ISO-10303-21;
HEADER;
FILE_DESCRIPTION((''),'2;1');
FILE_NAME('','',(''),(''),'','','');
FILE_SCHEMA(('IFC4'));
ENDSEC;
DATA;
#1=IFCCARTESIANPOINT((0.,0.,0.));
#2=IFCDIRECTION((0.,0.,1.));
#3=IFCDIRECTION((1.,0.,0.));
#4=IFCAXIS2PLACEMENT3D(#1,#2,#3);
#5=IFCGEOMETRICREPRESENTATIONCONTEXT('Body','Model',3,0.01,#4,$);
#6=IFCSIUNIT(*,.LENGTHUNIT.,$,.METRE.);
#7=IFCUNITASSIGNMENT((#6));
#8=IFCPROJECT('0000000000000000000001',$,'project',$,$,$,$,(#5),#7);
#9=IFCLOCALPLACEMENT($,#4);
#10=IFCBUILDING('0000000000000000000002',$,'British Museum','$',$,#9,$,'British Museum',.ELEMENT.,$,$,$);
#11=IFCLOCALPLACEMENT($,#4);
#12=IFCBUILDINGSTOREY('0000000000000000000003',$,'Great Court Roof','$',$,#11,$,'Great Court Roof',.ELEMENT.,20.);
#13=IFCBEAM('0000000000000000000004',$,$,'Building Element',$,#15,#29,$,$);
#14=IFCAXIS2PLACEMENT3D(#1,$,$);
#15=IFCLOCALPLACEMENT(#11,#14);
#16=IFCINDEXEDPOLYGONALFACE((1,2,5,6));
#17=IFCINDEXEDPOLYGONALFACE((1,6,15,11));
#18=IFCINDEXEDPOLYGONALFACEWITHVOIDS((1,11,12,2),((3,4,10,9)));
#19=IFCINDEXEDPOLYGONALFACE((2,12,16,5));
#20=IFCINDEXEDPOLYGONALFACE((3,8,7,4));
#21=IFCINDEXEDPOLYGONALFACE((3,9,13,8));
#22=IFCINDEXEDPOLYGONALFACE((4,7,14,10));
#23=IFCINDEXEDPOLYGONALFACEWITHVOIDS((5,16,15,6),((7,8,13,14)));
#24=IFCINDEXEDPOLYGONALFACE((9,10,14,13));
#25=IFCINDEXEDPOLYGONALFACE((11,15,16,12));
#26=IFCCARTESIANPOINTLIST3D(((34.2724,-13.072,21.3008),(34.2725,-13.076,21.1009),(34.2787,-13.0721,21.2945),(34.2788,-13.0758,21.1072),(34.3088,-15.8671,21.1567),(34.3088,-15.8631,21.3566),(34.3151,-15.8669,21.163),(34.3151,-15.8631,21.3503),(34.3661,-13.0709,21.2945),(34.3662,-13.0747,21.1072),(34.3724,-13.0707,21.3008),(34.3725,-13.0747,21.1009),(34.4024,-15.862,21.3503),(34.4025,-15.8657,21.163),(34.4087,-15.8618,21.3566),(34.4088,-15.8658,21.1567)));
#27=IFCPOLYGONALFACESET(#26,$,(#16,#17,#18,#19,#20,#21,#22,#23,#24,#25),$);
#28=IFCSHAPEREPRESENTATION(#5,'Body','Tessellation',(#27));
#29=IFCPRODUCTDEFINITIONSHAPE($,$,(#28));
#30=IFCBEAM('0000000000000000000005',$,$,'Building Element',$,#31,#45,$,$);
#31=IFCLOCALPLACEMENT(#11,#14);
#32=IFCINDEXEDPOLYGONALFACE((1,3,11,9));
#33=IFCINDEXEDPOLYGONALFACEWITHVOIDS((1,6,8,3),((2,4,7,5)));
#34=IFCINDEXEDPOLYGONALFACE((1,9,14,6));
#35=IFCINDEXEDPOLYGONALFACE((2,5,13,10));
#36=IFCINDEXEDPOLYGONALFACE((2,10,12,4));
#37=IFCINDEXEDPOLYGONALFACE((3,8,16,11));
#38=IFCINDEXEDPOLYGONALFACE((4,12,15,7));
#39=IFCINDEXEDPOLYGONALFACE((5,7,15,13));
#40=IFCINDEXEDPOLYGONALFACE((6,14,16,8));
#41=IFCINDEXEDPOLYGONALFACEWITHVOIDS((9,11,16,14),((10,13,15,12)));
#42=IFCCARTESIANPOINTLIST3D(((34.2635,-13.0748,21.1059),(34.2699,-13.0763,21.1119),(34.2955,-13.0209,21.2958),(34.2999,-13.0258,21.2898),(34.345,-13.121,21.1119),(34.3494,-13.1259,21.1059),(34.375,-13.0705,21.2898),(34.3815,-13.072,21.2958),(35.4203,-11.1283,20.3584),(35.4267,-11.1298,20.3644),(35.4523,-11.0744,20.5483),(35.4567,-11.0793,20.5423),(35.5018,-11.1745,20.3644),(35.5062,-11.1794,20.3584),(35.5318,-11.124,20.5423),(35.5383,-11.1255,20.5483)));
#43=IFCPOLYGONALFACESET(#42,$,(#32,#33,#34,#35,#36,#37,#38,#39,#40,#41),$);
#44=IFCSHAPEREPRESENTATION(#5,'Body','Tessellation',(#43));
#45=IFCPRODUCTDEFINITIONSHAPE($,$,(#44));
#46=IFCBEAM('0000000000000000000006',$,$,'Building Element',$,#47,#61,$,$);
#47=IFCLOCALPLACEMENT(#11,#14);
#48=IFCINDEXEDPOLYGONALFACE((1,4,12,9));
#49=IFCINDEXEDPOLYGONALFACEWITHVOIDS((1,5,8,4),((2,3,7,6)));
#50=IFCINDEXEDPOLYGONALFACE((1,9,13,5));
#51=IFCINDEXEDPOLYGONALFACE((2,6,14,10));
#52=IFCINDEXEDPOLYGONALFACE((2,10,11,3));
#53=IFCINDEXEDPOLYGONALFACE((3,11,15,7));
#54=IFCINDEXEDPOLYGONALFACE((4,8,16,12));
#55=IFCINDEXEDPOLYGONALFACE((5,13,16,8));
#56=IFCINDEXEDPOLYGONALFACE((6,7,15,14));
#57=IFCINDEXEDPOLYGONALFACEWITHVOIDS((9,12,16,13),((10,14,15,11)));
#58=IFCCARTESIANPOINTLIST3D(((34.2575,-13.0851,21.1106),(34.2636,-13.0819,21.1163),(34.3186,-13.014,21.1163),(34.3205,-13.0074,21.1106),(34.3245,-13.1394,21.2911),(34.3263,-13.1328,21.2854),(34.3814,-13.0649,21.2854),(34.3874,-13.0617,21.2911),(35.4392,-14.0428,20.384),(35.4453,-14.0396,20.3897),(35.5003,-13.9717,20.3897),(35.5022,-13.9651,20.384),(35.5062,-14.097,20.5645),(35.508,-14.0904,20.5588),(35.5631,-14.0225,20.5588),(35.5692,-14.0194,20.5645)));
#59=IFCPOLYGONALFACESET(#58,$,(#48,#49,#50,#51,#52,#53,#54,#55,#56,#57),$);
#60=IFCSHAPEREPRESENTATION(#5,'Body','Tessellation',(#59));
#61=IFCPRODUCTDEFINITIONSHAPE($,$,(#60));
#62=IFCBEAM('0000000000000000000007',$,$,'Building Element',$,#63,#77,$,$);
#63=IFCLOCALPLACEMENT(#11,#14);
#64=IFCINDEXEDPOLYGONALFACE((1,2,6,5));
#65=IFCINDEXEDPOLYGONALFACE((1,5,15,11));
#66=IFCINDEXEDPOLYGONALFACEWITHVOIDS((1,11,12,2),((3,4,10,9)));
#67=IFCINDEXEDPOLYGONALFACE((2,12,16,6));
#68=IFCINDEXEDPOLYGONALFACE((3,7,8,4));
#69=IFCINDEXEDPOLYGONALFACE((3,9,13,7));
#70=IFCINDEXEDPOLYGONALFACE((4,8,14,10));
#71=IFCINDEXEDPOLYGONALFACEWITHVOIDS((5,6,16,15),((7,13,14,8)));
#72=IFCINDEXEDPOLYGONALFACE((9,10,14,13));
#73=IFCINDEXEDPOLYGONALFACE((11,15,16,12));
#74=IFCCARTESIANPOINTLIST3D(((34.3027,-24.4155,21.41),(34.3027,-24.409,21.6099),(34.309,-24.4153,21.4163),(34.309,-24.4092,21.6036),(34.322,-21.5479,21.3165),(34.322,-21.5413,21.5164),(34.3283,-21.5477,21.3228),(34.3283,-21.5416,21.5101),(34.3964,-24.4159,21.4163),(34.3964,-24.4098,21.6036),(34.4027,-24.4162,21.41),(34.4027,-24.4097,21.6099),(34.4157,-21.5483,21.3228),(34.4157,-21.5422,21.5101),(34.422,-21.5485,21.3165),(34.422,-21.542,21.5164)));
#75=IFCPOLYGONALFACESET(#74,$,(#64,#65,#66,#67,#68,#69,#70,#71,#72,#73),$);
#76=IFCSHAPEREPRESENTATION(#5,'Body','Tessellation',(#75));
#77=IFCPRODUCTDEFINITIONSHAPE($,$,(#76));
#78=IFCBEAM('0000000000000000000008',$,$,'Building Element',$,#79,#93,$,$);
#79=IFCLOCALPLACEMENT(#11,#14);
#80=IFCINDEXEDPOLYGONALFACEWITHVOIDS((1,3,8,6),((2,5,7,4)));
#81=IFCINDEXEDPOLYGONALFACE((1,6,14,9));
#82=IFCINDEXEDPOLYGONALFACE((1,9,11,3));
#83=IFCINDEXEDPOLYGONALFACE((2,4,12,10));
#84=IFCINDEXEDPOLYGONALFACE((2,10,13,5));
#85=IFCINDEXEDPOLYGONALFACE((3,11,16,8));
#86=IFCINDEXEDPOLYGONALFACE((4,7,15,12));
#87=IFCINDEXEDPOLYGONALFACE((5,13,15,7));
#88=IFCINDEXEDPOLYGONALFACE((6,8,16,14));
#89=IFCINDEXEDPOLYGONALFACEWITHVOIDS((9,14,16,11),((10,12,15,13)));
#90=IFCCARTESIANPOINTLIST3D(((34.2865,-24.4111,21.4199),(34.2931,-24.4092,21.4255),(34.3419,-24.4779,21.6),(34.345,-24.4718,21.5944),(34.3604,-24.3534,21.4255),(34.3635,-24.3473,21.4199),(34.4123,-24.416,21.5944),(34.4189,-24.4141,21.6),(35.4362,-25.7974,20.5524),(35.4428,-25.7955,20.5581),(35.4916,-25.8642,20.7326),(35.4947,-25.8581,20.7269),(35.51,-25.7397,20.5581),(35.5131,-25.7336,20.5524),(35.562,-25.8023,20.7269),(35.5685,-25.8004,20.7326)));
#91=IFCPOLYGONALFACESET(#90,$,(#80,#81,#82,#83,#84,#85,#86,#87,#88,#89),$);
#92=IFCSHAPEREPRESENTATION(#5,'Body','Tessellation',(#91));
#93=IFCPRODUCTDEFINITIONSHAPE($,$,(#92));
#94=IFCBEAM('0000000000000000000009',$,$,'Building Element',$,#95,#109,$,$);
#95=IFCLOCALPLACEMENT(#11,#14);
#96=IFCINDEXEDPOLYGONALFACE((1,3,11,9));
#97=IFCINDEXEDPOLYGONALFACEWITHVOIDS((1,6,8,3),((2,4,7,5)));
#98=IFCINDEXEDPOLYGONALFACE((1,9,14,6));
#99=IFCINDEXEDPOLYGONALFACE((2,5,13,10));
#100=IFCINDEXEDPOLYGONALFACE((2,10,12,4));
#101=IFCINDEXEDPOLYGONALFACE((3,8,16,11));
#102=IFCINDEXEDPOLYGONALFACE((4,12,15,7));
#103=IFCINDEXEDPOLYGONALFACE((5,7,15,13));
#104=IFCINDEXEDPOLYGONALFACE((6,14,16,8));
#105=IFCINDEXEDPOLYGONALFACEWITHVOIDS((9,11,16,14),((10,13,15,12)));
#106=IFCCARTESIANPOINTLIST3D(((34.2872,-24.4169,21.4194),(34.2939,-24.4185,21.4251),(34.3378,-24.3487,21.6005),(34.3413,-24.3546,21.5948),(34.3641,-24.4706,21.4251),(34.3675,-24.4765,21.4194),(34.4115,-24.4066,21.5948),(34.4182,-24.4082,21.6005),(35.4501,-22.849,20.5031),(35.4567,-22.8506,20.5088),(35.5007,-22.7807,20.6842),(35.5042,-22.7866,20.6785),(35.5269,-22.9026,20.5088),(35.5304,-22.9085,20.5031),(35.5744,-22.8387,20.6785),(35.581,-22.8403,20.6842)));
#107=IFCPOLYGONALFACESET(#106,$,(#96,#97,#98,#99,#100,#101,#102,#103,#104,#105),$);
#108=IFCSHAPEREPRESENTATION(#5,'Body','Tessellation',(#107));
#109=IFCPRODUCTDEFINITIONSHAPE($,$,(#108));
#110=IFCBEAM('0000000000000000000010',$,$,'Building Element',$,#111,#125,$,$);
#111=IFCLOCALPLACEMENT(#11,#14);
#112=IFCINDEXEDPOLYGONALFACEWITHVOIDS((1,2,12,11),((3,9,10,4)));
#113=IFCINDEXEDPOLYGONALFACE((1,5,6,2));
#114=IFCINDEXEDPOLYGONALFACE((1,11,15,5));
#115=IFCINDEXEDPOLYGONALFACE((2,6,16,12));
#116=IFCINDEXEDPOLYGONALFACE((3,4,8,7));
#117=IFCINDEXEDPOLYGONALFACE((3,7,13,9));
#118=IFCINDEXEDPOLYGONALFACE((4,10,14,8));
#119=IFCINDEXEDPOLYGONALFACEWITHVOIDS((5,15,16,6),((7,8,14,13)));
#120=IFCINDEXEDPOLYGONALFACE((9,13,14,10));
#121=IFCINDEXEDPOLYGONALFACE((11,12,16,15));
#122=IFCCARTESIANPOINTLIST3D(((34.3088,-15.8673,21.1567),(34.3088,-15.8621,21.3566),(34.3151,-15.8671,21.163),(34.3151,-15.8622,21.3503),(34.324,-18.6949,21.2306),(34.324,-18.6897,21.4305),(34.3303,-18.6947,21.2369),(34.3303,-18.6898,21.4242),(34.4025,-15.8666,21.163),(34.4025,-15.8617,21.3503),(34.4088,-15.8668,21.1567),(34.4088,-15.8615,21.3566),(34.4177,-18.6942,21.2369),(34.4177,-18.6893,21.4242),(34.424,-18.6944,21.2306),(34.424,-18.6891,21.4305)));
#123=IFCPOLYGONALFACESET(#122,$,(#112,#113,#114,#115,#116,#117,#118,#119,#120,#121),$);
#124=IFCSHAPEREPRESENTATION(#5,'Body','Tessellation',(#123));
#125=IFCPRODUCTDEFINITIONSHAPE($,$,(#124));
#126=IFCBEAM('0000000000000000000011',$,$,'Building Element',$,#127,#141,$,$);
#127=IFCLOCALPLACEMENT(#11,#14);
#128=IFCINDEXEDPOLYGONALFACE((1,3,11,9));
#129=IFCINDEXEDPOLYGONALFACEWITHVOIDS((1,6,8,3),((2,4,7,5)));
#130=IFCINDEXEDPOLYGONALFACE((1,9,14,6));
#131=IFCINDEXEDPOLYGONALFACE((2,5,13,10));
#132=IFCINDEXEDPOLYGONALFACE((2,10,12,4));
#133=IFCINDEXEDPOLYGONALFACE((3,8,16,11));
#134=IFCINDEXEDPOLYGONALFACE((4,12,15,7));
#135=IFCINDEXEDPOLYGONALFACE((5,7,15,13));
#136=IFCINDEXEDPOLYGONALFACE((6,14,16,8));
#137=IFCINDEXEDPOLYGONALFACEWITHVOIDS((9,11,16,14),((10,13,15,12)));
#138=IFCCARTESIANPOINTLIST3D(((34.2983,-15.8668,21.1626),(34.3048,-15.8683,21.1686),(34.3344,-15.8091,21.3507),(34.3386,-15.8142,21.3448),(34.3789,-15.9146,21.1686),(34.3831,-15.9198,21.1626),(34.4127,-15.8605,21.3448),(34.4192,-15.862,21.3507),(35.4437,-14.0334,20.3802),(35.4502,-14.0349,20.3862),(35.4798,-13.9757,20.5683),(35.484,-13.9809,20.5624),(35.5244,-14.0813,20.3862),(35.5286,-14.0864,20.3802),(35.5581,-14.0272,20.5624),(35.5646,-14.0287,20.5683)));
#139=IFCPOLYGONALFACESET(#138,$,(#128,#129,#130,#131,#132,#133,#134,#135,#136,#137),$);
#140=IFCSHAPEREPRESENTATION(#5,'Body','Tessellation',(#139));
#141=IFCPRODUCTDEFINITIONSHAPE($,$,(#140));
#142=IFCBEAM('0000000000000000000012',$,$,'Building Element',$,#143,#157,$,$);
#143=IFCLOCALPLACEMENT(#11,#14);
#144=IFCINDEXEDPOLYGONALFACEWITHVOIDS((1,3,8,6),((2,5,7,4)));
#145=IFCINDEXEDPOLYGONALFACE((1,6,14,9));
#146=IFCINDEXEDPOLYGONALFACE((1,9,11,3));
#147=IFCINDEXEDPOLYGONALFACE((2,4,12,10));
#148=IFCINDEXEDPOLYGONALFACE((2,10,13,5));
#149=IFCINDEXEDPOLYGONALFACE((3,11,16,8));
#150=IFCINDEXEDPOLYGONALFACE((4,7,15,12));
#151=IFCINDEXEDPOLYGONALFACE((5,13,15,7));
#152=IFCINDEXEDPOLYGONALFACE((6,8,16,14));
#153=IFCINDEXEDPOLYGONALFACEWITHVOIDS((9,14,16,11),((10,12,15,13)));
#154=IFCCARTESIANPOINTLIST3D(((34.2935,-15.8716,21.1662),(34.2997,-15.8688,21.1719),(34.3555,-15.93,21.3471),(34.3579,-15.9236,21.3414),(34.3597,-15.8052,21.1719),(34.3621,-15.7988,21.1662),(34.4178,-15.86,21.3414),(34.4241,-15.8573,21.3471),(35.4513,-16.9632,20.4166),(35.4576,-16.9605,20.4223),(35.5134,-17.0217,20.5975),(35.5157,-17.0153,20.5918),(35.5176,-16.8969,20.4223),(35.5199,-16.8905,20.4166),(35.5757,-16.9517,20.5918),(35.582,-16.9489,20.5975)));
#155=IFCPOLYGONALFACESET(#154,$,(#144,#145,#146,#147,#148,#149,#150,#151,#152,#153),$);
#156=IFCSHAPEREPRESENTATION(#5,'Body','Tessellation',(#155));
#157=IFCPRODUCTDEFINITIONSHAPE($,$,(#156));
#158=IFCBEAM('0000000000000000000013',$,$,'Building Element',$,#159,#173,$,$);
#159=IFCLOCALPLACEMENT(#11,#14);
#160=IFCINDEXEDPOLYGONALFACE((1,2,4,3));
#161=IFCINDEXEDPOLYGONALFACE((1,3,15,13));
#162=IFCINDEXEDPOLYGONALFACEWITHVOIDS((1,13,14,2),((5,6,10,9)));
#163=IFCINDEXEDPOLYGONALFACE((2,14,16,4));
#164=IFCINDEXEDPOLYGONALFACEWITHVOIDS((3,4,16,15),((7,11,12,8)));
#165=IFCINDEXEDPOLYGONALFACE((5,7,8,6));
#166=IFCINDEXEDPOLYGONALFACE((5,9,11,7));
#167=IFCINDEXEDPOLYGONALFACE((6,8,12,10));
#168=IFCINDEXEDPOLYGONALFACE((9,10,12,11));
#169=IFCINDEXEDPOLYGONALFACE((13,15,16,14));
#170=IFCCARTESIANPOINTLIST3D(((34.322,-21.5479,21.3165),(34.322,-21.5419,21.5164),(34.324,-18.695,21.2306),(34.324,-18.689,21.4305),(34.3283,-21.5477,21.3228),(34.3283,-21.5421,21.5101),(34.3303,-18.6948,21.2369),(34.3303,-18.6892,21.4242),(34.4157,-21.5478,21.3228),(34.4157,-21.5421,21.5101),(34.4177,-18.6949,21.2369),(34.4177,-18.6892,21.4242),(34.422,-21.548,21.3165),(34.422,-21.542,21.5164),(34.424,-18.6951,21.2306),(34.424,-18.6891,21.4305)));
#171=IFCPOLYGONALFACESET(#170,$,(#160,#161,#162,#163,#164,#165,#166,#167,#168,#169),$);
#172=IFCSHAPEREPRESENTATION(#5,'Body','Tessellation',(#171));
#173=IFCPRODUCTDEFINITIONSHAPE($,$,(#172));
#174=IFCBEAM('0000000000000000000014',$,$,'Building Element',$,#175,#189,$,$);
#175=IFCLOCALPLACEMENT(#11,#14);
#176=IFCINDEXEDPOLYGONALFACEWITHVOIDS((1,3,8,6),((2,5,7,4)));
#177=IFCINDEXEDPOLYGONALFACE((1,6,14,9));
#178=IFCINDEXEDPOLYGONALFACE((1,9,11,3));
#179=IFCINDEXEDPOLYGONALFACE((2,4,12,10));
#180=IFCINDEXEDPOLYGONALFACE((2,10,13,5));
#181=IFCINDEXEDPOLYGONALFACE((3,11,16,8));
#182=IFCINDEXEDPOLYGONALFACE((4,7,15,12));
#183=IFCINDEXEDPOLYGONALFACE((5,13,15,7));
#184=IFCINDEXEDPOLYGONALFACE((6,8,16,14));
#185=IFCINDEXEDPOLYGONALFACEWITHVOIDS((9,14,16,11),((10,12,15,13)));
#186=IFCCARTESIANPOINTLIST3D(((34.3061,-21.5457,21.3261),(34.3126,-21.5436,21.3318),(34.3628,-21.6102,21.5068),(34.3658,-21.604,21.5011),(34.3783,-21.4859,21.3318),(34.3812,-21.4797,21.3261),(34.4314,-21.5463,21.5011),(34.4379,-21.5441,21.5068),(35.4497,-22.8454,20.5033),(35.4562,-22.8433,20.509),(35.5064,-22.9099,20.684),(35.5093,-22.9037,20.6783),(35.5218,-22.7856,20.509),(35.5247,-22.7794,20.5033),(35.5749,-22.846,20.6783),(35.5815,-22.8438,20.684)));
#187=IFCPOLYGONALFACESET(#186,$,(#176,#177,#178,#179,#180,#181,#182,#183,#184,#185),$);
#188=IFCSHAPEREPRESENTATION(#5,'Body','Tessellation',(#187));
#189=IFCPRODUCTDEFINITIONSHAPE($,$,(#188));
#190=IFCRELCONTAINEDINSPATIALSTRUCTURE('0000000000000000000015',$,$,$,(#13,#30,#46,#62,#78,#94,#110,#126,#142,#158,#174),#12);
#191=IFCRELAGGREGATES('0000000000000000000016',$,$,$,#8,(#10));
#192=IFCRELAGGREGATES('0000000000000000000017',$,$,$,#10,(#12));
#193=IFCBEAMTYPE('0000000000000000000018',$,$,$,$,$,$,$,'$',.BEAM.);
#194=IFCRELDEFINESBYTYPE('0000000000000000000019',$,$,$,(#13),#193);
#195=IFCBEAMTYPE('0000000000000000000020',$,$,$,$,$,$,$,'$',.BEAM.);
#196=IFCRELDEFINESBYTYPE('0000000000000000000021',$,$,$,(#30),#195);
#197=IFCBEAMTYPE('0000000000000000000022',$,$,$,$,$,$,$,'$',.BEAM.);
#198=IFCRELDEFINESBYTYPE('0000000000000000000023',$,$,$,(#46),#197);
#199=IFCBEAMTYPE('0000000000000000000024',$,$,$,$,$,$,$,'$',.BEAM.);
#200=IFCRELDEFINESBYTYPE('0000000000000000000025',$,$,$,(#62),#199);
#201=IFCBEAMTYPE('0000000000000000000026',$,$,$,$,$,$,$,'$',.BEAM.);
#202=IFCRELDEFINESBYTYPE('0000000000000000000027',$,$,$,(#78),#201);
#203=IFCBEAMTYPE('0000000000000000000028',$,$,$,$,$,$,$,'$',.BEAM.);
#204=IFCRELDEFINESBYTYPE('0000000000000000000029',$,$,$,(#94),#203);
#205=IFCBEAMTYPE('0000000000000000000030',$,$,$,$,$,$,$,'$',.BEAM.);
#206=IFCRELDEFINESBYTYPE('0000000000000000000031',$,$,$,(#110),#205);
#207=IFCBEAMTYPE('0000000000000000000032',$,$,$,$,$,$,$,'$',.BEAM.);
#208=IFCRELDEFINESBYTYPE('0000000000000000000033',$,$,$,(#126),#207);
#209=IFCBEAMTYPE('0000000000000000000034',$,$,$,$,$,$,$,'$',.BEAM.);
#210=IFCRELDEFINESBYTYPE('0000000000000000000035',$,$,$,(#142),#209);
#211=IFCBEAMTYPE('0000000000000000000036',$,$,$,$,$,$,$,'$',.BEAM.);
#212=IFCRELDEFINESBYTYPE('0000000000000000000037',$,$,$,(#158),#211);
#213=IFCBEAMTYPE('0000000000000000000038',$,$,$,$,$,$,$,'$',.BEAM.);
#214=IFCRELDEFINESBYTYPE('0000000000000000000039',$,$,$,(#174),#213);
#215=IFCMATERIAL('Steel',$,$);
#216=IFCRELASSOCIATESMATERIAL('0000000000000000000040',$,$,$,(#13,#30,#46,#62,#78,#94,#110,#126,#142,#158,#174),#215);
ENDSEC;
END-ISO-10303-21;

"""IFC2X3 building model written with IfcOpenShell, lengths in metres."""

from ifc_helpers import new_model, si_unit, frame, origin_with_axes, origin_2d, place, context, project, spatial, hollow_rectangle, extrude, material, type_object, element, save


model = new_model("IFC2X3")

# Units and contexts
model_context = context("Model", 3, precision=0.01, world=origin_with_axes(), identifier="Body")
ifc_project = project(units=[si_unit("LENGTHUNIT", "METRE")], contexts=[model_context])

# Building, storey
building_placement = place(None, origin_with_axes())
building = spatial("IfcBuilding", under=ifc_project, at=building_placement, Name="British Museum", Description="$", LongName="British Museum", CompositionType="ELEMENT")
storey_placement = place(None, origin_with_axes())
storey = spatial("IfcBuildingStorey", under=building, at=storey_placement, Name="Great Court Roof", Description="$", LongName="Great Court Roof", CompositionType="ELEMENT", Elevation=20.0)

# Beams
ifc_material = material(Name="Steel")
beam_type_1 = type_object("IfcBeamType", ElementType="$", PredefinedType="BEAM")
beam_1_placement = place(None, origin_with_axes())
element("IfcBeam", 1, at=beam_1_placement, inside=storey, type_object=beam_type_1, material=ifc_material, Description="Building Element", context=model_context, shape_type="SweptSolid", body=[
    extrude(hollow_rectangle(XDim=0.1, YDim=0.2, WallThickness=0.0063, InnerFilletRadius=-0.0063, OuterFilletRadius=0.0, at=origin_2d()), frame((34.3225, -13.0734, 21.2008), z_axis=(0.013007, -0.999715, 0.019998), x_axis=(0.999915, 0.013009, 0.0)), (0.0, 0.0, 1.0), 2.7918),
])
beam_type_2 = type_object("IfcBeamType", ElementType="$", PredefinedType="BEAM")
beam_2_placement = place(None, origin_with_axes())
element("IfcBeam", 2, at=beam_2_placement, inside=storey, type_object=beam_type_2, material=ifc_material, Description="Building Element", context=model_context, shape_type="SweptSolid", body=[
    extrude(hollow_rectangle(XDim=0.1, YDim=0.2, WallThickness=0.0063, InnerFilletRadius=-0.0063, OuterFilletRadius=0.0, at=origin_2d()), frame((34.3225, -13.0734, 21.2008), z_axis=(0.485142, 0.816313, -0.313481), x_axis=(-0.859644, 0.510894, 0.0)), (0.0, 0.0, 1.0), 2.3845),
])
beam_type_3 = type_object("IfcBeamType", ElementType="$", PredefinedType="BEAM")
beam_3_placement = place(None, origin_with_axes())
element("IfcBeam", 3, at=beam_3_placement, inside=storey, type_object=beam_type_3, material=ifc_material, Description="Building Element", context=model_context, shape_type="SweptSolid", body=[
    extrude(hollow_rectangle(XDim=0.1, YDim=0.2, WallThickness=0.0063, InnerFilletRadius=-0.0063, OuterFilletRadius=0.0, at=origin_2d()), frame((34.3225, -13.0734, 21.2008), z_axis=(0.701037, -0.568124, -0.431025), x_axis=(0.629612, 0.77691, 0.0)), (0.0, 0.0, 1.0), 1.6857),
])
beam_type_4 = type_object("IfcBeamType", ElementType="$", PredefinedType="BEAM")
beam_4_placement = place(None, origin_with_axes())
element("IfcBeam", 4, at=beam_4_placement, inside=storey, type_object=beam_type_4, material=ifc_material, Description="Building Element", context=model_context, shape_type="SweptSolid", body=[
    extrude(hollow_rectangle(XDim=0.1, YDim=0.2, WallThickness=0.0063, InnerFilletRadius=-0.0063, OuterFilletRadius=0.0, at=origin_2d()), frame((34.3527, -24.4126, 21.5099), z_axis=(0.006738, 0.999446, -0.032587), x_axis=(-0.999977, 0.006742, 0.0)), (0.0, 0.0, 1.0), 2.8692),
])
beam_type_5 = type_object("IfcBeamType", ElementType="$", PredefinedType="BEAM")
beam_5_placement = place(None, origin_with_axes())
element("IfcBeam", 5, at=beam_5_placement, inside=storey, type_object=beam_type_5, material=ifc_material, Description="Building Element", context=model_context, shape_type="SweptSolid", body=[
    extrude(hollow_rectangle(XDim=0.1, YDim=0.2, WallThickness=0.0063, InnerFilletRadius=-0.0063, OuterFilletRadius=0.0, at=origin_2d()), frame((34.3527, -24.4126, 21.5099), z_axis=(0.57512, -0.693506, -0.433921), x_axis=(0.769748, 0.638347, 0.0)), (0.0, 0.0, 1.0), 1.999),
])
beam_type_6 = type_object("IfcBeamType", ElementType="$", PredefinedType="BEAM")
beam_6_placement = place(None, origin_with_axes())
element("IfcBeam", 6, at=beam_6_placement, inside=storey, type_object=beam_type_6, material=ifc_material, Description="Building Element", context=model_context, shape_type="SweptSolid", body=[
    extrude(hollow_rectangle(XDim=0.1, YDim=0.2, WallThickness=0.0063, InnerFilletRadius=-0.0063, OuterFilletRadius=0.0, at=origin_2d()), frame((34.3527, -24.4126, 21.5099), z_axis=(0.539247, 0.727094, -0.424909), x_axis=(-0.803209, 0.595697, 0.0)), (0.0, 0.0, 1.0), 2.1565),
])
beam_type_7 = type_object("IfcBeamType", ElementType="$", PredefinedType="BEAM")
beam_7_placement = place(None, origin_with_axes())
element("IfcBeam", 7, at=beam_7_placement, inside=storey, type_object=beam_type_7, material=ifc_material, Description="Building Element", context=model_context, shape_type="SweptSolid", body=[
    extrude(hollow_rectangle(XDim=0.1, YDim=0.2, WallThickness=0.0063, InnerFilletRadius=-0.0063, OuterFilletRadius=0.0, at=origin_2d()), frame((34.3588, -15.8644, 21.2567), z_axis=(0.005392, -0.999644, 0.026112), x_axis=(0.999985, 0.005394, 0.0)), (0.0, 0.0, 1.0), 2.8286),
])
beam_type_8 = type_object("IfcBeamType", ElementType="$", PredefinedType="BEAM")
beam_8_placement = place(None, origin_with_axes())
element("IfcBeam", 8, at=beam_8_placement, inside=storey, type_object=beam_type_8, material=ifc_material, Description="Building Element", context=model_context, shape_type="SweptSolid", body=[
    extrude(hollow_rectangle(XDim=0.1, YDim=0.2, WallThickness=0.0063, InnerFilletRadius=-0.0063, OuterFilletRadius=0.0, at=origin_2d()), frame((34.3588, -15.8644, 21.2567), z_axis=(0.498225, 0.797466, -0.340324), x_axis=(-0.84809, 0.529852, 0.0)), (0.0, 0.0, 1.0), 2.299),
])
beam_type_9 = type_object("IfcBeamType", ElementType="$", PredefinedType="BEAM")
beam_9_placement = place(None, origin_with_axes())
element("IfcBeam", 9, at=beam_9_placement, inside=storey, type_object=beam_type_9, material=ifc_material, Description="Building Element", context=model_context, shape_type="SweptSolid", body=[
    extrude(hollow_rectangle(XDim=0.1, YDim=0.2, WallThickness=0.0063, InnerFilletRadius=-0.0063, OuterFilletRadius=0.0, at=origin_2d()), frame((34.3588, -15.8644, 21.2567), z_axis=(0.658228, -0.62059, -0.42615), x_axis=(0.685999, 0.727603, 0.0)), (0.0, 0.0, 1.0), 1.7591),
])
beam_type_10 = type_object("IfcBeamType", ElementType="$", PredefinedType="BEAM")
beam_10_placement = place(None, origin_with_axes())
element("IfcBeam", 10, at=beam_10_placement, inside=storey, type_object=beam_type_10, material=ifc_material, Description="Building Element", context=model_context, shape_type="SweptSolid", body=[
    extrude(hollow_rectangle(XDim=0.1, YDim=0.2, WallThickness=0.0063, InnerFilletRadius=-0.0063, OuterFilletRadius=0.0, at=origin_2d()), frame((34.372, -21.5449, 21.4164), z_axis=(0.000704, 0.999547, -0.030104), x_axis=(-1.0, 0.000705, 0.0)), (0.0, 0.0, 1.0), 2.8542),
])
beam_type_11 = type_object("IfcBeamType", ElementType="$", PredefinedType="BEAM")
beam_11_placement = place(None, origin_with_axes())
element("IfcBeam", 11, at=beam_11_placement, inside=storey, type_object=beam_type_11, material=ifc_material, Description="Building Element", context=model_context, shape_type="SweptSolid", body=[
    extrude(hollow_rectangle(XDim=0.1, YDim=0.2, WallThickness=0.0063, InnerFilletRadius=-0.0063, OuterFilletRadius=0.0, at=origin_2d()), frame((34.372, -21.5449, 21.4164), z_axis=(0.596607, -0.678073, -0.429274), x_axis=(0.750767, 0.660567, 0.0)), (0.0, 0.0, 1.0), 1.9167),
])

save(model, "model.ifc")
